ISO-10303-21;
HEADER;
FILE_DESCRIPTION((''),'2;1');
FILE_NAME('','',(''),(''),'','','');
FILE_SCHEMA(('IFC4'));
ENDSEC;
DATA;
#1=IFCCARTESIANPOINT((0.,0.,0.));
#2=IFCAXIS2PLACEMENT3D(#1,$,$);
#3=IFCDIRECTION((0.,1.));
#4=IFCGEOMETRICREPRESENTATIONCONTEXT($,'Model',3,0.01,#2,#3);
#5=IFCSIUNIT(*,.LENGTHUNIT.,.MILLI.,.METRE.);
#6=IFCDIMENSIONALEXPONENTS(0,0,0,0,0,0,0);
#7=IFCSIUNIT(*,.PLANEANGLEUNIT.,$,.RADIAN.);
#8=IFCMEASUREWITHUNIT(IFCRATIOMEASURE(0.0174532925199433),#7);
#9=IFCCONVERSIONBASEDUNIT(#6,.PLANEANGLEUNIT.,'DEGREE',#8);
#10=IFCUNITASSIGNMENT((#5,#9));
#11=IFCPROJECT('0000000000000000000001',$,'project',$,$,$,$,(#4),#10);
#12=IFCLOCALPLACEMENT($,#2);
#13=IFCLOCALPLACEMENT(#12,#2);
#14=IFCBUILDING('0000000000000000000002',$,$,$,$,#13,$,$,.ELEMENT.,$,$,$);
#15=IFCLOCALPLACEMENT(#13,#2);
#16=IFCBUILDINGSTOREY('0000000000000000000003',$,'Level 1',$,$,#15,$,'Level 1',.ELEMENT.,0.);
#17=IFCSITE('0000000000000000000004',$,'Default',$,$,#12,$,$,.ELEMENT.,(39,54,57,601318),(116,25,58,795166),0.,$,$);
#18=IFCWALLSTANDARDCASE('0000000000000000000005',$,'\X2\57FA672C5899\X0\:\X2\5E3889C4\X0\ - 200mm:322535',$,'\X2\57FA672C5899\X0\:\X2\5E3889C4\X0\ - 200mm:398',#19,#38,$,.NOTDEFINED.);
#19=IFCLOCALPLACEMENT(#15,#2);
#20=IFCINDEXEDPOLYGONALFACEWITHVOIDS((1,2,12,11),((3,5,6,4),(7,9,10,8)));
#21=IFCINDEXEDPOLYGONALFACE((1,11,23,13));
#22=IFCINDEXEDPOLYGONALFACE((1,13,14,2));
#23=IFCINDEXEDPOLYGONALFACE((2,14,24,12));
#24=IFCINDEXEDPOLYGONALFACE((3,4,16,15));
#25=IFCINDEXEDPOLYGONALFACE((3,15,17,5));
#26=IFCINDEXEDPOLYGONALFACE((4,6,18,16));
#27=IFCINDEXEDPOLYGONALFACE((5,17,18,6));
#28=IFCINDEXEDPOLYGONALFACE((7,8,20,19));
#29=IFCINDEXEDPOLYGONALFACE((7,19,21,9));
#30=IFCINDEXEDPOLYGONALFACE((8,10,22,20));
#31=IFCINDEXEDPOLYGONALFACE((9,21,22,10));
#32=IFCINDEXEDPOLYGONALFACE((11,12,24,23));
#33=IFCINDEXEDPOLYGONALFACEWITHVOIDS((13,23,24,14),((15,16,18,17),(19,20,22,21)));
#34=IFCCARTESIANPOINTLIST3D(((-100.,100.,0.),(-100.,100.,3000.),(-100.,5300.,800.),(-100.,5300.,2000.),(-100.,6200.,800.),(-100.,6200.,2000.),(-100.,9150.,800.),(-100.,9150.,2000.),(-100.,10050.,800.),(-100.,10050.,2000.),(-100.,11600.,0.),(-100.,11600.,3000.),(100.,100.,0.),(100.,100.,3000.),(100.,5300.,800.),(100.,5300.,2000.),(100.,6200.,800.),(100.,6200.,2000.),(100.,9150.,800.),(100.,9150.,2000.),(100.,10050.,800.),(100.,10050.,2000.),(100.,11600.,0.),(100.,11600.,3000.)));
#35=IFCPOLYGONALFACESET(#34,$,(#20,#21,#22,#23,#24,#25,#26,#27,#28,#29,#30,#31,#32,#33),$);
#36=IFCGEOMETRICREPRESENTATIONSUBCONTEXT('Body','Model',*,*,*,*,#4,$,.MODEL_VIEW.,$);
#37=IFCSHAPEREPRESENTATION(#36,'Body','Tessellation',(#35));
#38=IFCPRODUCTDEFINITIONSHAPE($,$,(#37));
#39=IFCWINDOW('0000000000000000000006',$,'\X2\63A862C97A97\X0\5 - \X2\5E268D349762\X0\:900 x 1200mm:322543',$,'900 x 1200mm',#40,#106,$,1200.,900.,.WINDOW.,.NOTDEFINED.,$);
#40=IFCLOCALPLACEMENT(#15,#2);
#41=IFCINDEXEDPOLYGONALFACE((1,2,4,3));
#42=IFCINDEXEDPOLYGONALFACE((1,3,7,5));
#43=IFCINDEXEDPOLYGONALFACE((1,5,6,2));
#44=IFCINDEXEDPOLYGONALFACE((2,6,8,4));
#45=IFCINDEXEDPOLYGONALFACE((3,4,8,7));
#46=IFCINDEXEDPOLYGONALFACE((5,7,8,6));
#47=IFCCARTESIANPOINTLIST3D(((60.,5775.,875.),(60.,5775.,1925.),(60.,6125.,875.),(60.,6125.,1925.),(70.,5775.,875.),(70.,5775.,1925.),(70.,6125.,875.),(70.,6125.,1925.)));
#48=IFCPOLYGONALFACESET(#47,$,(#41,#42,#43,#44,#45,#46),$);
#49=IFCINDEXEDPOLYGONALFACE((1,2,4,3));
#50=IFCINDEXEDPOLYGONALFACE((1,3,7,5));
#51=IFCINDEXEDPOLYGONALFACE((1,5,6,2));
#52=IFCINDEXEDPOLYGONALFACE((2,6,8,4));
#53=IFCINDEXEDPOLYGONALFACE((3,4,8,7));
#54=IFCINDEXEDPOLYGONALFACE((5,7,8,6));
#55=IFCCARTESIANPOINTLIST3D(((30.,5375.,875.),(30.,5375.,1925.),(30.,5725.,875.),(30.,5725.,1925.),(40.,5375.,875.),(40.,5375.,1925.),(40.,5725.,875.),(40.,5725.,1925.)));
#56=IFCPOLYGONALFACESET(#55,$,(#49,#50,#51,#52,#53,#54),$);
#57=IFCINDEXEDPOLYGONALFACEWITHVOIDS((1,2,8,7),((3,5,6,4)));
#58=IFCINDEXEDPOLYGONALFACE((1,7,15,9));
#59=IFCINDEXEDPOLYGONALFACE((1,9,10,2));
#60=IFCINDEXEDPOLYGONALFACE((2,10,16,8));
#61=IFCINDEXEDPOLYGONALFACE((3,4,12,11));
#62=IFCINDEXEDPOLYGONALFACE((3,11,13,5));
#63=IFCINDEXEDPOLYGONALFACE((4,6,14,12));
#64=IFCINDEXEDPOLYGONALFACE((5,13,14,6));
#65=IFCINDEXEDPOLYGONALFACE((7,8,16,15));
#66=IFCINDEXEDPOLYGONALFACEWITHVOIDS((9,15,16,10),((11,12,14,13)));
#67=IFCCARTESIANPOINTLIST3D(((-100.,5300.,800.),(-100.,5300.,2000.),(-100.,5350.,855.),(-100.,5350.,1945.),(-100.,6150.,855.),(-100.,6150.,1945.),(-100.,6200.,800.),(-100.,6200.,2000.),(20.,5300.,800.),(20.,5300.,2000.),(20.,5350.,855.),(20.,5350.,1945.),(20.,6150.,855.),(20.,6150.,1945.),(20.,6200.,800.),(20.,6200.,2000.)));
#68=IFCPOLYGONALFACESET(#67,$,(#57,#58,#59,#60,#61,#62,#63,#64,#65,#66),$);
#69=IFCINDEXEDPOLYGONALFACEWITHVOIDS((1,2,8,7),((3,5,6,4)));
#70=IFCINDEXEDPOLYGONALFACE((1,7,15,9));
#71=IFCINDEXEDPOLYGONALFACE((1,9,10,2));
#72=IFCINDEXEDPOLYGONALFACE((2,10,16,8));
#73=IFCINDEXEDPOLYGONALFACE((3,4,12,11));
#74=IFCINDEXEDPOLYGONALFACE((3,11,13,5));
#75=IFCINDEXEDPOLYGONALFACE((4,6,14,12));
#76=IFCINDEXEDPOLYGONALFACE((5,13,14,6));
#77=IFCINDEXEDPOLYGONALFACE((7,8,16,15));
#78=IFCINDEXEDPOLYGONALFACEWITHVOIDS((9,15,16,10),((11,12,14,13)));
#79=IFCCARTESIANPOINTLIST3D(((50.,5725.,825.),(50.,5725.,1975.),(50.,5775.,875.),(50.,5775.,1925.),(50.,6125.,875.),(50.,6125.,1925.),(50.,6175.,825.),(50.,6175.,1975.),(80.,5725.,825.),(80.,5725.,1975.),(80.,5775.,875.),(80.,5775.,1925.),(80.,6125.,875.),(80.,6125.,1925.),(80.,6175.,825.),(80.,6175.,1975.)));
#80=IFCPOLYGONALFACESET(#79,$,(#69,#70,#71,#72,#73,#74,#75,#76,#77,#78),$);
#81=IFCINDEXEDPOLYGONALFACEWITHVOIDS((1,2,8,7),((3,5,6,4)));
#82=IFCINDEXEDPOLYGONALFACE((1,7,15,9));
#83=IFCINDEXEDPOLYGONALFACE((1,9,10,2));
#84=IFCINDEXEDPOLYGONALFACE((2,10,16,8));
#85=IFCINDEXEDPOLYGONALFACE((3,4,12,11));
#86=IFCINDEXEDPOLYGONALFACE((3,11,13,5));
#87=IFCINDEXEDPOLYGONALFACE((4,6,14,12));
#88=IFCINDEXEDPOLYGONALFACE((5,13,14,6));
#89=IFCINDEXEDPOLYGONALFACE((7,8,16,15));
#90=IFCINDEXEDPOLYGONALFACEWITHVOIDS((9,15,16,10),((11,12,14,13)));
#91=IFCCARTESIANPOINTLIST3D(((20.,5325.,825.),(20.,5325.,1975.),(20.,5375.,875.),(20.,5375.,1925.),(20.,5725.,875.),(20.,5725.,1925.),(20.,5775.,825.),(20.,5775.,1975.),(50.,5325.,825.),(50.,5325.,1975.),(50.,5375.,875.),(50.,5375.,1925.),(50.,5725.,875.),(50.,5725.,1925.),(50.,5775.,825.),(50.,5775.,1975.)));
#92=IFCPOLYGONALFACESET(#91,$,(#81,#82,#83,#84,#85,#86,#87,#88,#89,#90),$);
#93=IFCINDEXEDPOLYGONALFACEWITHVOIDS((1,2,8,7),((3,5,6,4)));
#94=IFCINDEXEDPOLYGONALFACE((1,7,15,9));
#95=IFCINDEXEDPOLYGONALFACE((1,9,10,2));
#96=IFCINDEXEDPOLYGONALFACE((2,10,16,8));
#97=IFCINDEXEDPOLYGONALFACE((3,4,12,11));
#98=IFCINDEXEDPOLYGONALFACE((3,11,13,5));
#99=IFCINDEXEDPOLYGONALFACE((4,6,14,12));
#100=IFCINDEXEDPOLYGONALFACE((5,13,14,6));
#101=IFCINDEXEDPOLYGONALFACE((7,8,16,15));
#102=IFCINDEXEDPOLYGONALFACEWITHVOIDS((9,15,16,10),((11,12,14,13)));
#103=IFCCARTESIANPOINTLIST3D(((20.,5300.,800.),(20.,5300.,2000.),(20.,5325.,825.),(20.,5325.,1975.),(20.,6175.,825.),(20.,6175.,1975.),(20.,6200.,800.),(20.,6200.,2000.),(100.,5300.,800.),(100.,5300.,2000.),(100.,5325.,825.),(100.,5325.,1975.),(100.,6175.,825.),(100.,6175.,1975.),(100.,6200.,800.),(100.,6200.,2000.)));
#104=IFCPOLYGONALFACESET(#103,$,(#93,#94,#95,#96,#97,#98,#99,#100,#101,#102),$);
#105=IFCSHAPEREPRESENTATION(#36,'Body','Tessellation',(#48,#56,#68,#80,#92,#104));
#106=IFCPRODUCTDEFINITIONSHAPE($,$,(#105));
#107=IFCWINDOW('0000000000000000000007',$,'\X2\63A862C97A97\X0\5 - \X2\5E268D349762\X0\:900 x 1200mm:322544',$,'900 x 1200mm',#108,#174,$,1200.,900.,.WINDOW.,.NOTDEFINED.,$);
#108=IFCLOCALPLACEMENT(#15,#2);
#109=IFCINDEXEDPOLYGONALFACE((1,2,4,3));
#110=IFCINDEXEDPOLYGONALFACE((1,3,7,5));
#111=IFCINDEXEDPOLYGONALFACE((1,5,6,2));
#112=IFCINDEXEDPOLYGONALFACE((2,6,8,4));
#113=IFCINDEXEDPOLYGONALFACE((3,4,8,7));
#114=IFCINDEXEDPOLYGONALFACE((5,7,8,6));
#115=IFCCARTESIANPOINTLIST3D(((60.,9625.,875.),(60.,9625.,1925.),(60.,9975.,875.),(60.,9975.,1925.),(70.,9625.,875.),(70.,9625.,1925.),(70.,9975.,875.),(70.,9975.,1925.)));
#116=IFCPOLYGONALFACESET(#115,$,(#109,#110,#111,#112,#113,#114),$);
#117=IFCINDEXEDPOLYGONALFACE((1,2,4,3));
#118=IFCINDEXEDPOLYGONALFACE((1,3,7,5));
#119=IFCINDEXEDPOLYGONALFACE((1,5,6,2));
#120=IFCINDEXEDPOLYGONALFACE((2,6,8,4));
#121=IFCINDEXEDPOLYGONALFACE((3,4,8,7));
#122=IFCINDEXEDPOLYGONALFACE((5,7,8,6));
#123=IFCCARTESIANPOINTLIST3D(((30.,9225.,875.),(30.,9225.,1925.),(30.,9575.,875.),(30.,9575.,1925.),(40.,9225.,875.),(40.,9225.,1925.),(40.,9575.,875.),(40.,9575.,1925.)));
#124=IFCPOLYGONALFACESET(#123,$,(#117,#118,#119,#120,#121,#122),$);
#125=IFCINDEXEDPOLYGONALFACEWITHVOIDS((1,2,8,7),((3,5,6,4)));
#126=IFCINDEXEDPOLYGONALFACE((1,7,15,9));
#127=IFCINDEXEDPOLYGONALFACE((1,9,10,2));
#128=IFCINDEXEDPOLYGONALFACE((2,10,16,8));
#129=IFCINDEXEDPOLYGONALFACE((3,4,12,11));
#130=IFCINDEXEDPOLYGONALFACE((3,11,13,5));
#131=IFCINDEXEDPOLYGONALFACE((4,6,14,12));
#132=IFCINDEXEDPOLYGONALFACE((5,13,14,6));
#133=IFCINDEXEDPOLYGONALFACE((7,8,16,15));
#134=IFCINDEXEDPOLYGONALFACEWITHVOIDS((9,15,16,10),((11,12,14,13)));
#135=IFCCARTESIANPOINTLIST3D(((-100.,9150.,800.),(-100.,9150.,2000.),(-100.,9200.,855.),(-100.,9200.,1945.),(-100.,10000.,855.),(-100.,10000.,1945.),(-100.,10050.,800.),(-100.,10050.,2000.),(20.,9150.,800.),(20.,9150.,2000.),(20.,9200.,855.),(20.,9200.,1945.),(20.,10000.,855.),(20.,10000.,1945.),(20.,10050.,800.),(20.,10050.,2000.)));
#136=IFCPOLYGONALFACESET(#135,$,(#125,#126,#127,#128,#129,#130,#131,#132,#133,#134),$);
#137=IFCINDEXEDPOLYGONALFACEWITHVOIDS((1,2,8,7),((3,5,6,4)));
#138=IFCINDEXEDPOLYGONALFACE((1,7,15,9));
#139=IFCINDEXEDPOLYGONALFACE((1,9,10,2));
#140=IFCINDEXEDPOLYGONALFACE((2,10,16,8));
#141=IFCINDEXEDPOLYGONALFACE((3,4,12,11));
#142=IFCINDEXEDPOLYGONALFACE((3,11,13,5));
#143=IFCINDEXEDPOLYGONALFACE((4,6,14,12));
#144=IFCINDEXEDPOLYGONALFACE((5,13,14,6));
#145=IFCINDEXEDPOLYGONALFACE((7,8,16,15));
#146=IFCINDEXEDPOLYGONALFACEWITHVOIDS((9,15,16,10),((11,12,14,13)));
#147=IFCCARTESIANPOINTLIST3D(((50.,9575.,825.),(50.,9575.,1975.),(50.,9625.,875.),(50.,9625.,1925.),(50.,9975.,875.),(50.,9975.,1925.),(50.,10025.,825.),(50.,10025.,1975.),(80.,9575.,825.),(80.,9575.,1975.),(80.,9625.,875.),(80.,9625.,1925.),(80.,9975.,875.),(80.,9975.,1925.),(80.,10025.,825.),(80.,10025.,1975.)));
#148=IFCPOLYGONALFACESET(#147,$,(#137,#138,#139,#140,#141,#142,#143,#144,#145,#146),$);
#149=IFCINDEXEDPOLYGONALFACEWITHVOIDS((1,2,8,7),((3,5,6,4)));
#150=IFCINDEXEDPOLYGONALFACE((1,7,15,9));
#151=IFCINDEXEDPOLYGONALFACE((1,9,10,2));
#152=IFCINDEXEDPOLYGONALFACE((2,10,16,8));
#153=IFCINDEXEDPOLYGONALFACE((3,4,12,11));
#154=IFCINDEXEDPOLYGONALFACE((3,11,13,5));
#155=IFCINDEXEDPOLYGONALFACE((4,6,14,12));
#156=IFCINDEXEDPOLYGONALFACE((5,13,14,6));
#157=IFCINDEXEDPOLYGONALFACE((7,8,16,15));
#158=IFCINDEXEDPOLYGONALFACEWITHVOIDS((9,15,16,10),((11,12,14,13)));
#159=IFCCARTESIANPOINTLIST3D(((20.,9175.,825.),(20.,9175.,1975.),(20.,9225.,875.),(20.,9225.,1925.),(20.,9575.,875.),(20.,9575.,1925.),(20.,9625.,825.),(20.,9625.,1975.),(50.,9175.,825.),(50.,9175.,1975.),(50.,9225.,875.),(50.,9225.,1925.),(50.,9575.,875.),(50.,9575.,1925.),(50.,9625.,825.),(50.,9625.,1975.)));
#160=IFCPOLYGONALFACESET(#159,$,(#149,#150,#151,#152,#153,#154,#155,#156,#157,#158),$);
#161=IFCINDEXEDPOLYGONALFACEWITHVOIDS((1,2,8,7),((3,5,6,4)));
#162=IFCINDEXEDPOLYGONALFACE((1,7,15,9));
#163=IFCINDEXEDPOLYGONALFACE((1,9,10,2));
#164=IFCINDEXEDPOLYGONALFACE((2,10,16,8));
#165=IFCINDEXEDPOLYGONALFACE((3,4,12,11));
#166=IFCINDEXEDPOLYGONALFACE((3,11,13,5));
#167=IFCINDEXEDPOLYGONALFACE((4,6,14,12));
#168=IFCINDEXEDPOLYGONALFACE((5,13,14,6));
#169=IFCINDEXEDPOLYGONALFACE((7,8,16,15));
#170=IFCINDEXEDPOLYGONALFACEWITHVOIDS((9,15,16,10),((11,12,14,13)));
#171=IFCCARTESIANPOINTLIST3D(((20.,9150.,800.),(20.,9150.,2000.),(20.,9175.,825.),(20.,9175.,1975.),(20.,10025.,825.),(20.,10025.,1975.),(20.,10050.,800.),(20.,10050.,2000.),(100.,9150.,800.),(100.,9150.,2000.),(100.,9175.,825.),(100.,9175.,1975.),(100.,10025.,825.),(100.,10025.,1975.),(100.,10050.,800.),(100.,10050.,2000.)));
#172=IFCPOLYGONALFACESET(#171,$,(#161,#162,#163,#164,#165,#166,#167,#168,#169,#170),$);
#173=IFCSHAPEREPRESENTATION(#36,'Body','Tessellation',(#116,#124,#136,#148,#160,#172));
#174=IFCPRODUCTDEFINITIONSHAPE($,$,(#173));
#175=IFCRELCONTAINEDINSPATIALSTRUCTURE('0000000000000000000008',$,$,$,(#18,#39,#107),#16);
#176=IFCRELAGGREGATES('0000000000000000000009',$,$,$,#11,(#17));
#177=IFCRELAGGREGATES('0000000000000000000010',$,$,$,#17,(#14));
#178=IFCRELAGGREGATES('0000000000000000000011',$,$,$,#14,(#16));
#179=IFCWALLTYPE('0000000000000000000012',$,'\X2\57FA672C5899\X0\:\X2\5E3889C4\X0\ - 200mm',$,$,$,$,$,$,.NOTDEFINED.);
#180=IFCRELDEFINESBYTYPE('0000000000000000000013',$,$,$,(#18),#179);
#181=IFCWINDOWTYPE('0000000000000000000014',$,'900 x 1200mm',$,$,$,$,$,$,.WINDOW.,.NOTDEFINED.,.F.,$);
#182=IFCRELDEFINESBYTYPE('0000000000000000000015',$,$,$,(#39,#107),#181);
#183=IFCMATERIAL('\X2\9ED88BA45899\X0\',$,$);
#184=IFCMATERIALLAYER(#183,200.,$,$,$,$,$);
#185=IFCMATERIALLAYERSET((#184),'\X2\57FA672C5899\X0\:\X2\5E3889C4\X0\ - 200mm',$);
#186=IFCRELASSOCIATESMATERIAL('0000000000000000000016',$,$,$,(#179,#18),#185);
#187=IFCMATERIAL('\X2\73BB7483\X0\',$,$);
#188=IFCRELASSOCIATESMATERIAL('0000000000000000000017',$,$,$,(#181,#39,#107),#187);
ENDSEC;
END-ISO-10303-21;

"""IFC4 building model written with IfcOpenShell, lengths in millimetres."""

from ifc_helpers import new_model, entity, si_unit, converted_unit, direction, frame, frame_2d, origin, origin_2d_with_axis, place, context, subcontext, project, spatial, polyline, rectangle, outline, extrude, source, transform, mapped, material, layer, layer_set, layer_usage, type_object, type_shapes, element, fill, save


model = new_model("IFC4")

# Units and contexts
model_context = context("Model", 3, precision=0.01, world=origin(), true_north=direction((0.0, 1.0)))
body_context = subcontext(model_context, "Body", "Model", "MODEL_VIEW")
ifc_project = project(units=[si_unit("LENGTHUNIT", "METRE", prefix="MILLI"), converted_unit("PLANEANGLEUNIT", "DEGREE", entity("IfcRatioMeasure", 0.0174532925199433), si_unit("PLANEANGLEUNIT", "RADIAN"), dimensions=[0, 0, 0, 0, 0, 0, 0])], contexts=[model_context])

# Site, building, storey
site_placement = place(None, origin())
site = spatial("IfcSite", under=ifc_project, at=site_placement, Name="Default", CompositionType="ELEMENT", RefLatitude=(39, 54, 57, 601318), RefLongitude=(116, 25, 58, 795166), RefElevation=0.0)
building_placement = place(site_placement, origin())
building = spatial("IfcBuilding", under=site, at=building_placement, CompositionType="ELEMENT")
storey_placement = place(building_placement, origin())
storey = spatial("IfcBuildingStorey", under=building, at=storey_placement, Name="Level 1", LongName="Level 1", CompositionType="ELEMENT", Elevation=0.0)

# Shared definitions
ifc_material_1 = material(Name="默认墙")
ifc_layer_1 = layer(ifc_material_1, 200.0)
ifc_layer_set_1 = layer_set([ifc_layer_1], Name="基本墙:常规 - 200mm")
wall_type = type_object("IfcWallType", Name="基本墙:常规 - 200mm", PredefinedType="NOTDEFINED", material=ifc_layer_set_1)
ifc_material_2 = material(Name="玻璃")

# Wall, openings, windows
ifc_layer_usage_1 = layer_usage(ifc_layer_set_1, "AXIS2", "NEGATIVE", 100.0)
wall_1_placement = place(storey_placement, frame((0.0, 100.0, 0.0), z_axis=(0.0, 0.0, 1.0), x_axis=(0.0, 1.0, 0.0)))
wall_1 = element("IfcWallStandardCase", 1, at=wall_1_placement, inside=storey, type_object=wall_type, material=ifc_layer_usage_1, Name="基本墙:常规 - 200mm:322535", ObjectType="基本墙:常规 - 200mm:398", PredefinedType="NOTDEFINED", context=body_context, shape_type="SweptSolid", body=[
    extrude(rectangle(XDim=11500.0, YDim=200.0, at=frame_2d((5750.0, 0.0), x_axis=(-1.0, 0.0))), origin(), (0.0, 0.0, 1.0), 3000.0),
])
opening_1_placement = place(wall_1_placement, frame((6100.0, 100.0, 800.0)))
opening_1 = element("IfcOpeningElement", 2, at=opening_1_placement, cuts=wall_1, ObjectType="Opening", PredefinedType="OPENING", context=body_context, shape_type="SweptSolid", body=[
    extrude(rectangle(XDim=1200.0, YDim=900.0, at=frame_2d((600.0, 450.0), x_axis=(-1.0, 0.0))), frame((0.0, 0.0, 0.0), z_axis=(0.0, -1.0, 0.0), x_axis=(0.0, 0.0, 1.0)), (0.0, 0.0, 1.0), 200.0),
])
opening_2_placement = place(wall_1_placement, frame((9950.0, 100.0, 800.0)))
opening_2 = element("IfcOpeningElement", 3, at=opening_2_placement, cuts=wall_1, ObjectType="Opening", PredefinedType="OPENING", context=body_context, shape_type="SweptSolid", body=[
    extrude(rectangle(XDim=1200.0, YDim=900.0, at=frame_2d((600.0, 450.0), x_axis=(-1.0, 0.0))), frame((0.0, 0.0, 0.0), z_axis=(0.0, -1.0, 0.0), x_axis=(0.0, 0.0, 1.0)), (0.0, 0.0, 1.0), 200.0),
])
window_type_1 = type_object("IfcWindowType", Name="900 x 1200mm", ParameterTakesPrecedence=False, PartitioningType="NOTDEFINED", PredefinedType="WINDOW", material=ifc_material_2)
shared_shape_1 = source(origin(), body_context, "Body", "SweptSolid", [
    extrude(rectangle(XDim=10.0, YDim=350.0, at=origin_2d_with_axis()), frame((250.0, 165.0, 75.0), z_axis=(0.0, 0.0, 1.0), x_axis=(0.0, -1.0, 0.0)), (0.0, 0.0, 1.0), 1050.0),
    extrude(rectangle(XDim=10.0, YDim=350.0, at=frame_2d((0.0, 0.0), x_axis=(1.0, 0.0))), frame((650.0, 135.0, 75.0), z_axis=(0.0, 0.0, 1.0), x_axis=(0.0, -1.0, 0.0)), (0.0, 0.0, 1.0), 1050.0),
    extrude(outline(polyline([(-450.0, -600.0), (450.0, -600.0), (450.0, 600.0), (-450.0, 600.0), (-450.0, -600.0)]), holes=[polyline([(400.0, -545.0), (-400.0, -545.0), (-400.0, 545.0), (400.0, 545.0), (400.0, -545.0)])]), frame((450.0, 0.0, 600.0), z_axis=(0.0, 1.0, 0.0), x_axis=(1.0, 0.0, 0.0)), (0.0, 0.0, 1.0), 120.0),
    extrude(outline(polyline([(-225.0, -575.0), (225.0, -575.0), (225.0, 575.0), (-225.0, 575.0), (-225.0, -575.0)]), holes=[polyline([(-175.0, -525.0), (-175.0, 525.0), (175.0, 525.0), (175.0, -525.0), (-175.0, -525.0)])]), frame((250.0, 150.0, 600.0), z_axis=(0.0, 1.0, 0.0), x_axis=(-1.0, 0.0, 0.0)), (0.0, 0.0, 1.0), 30.0),
    extrude(outline(polyline([(-225.0, -575.0), (225.0, -575.0), (225.0, 575.0), (-225.0, 575.0), (-225.0, -575.0)]), holes=[polyline([(-175.0, -525.0), (-175.0, 525.0), (175.0, 525.0), (175.0, -525.0), (-175.0, -525.0)])]), frame((650.0, 120.0, 600.0), z_axis=(0.0, 1.0, 0.0), x_axis=(1.0, 0.0, 0.0)), (0.0, 0.0, 1.0), 30.0),
    extrude(outline(polyline([(-450.0, -600.0), (450.0, -600.0), (450.0, 600.0), (-450.0, 600.0), (-450.0, -600.0)]), holes=[polyline([(-425.0, 575.0), (425.0, 575.0), (425.0, -575.0), (-425.0, -575.0), (-425.0, 575.0)])]), frame((450.0, 120.0, 600.0), z_axis=(0.0, 1.0, 0.0), x_axis=(1.0, 0.0, 0.0)), (0.0, 0.0, 1.0), 80.0),
])
type_shapes(window_type_1, [shared_shape_1])
window_1_placement = place(opening_1_placement, frame((0.0, 0.0, 0.0), z_axis=(0.0, 0.0, 1.0), x_axis=(-1.0, 0.0, 0.0)))
window_1 = element("IfcWindow", 4, at=window_1_placement, inside=storey, type_object=window_type_1, material=ifc_material_2, Name="推拉窗5 - 带贴面:900 x 1200mm:322543", ObjectType="900 x 1200mm", OverallHeight=1200.0, OverallWidth=900.0, PartitioningType="NOTDEFINED", PredefinedType="WINDOW", context=body_context, shape_type="MappedRepresentation", body=[
    mapped(shared_shape_1, transform((0.0, 0.0, 0.0), scale=1.0)),
])
fill(opening_1, window_1)
window_2_placement = place(opening_2_placement, frame((0.0, 0.0, 0.0), z_axis=(0.0, 0.0, 1.0), x_axis=(-1.0, 0.0, 0.0)))
window_2 = element("IfcWindow", 5, at=window_2_placement, inside=storey, type_object=window_type_1, material=ifc_material_2, Name="推拉窗5 - 带贴面:900 x 1200mm:322544", ObjectType="900 x 1200mm", OverallHeight=1200.0, OverallWidth=900.0, PartitioningType="NOTDEFINED", PredefinedType="WINDOW", context=body_context, shape_type="MappedRepresentation", body=[
    mapped(shared_shape_1, transform((0.0, 0.0, 0.0), scale=1.0)),
])
fill(opening_2, window_2)

save(model, "model.ifc")
